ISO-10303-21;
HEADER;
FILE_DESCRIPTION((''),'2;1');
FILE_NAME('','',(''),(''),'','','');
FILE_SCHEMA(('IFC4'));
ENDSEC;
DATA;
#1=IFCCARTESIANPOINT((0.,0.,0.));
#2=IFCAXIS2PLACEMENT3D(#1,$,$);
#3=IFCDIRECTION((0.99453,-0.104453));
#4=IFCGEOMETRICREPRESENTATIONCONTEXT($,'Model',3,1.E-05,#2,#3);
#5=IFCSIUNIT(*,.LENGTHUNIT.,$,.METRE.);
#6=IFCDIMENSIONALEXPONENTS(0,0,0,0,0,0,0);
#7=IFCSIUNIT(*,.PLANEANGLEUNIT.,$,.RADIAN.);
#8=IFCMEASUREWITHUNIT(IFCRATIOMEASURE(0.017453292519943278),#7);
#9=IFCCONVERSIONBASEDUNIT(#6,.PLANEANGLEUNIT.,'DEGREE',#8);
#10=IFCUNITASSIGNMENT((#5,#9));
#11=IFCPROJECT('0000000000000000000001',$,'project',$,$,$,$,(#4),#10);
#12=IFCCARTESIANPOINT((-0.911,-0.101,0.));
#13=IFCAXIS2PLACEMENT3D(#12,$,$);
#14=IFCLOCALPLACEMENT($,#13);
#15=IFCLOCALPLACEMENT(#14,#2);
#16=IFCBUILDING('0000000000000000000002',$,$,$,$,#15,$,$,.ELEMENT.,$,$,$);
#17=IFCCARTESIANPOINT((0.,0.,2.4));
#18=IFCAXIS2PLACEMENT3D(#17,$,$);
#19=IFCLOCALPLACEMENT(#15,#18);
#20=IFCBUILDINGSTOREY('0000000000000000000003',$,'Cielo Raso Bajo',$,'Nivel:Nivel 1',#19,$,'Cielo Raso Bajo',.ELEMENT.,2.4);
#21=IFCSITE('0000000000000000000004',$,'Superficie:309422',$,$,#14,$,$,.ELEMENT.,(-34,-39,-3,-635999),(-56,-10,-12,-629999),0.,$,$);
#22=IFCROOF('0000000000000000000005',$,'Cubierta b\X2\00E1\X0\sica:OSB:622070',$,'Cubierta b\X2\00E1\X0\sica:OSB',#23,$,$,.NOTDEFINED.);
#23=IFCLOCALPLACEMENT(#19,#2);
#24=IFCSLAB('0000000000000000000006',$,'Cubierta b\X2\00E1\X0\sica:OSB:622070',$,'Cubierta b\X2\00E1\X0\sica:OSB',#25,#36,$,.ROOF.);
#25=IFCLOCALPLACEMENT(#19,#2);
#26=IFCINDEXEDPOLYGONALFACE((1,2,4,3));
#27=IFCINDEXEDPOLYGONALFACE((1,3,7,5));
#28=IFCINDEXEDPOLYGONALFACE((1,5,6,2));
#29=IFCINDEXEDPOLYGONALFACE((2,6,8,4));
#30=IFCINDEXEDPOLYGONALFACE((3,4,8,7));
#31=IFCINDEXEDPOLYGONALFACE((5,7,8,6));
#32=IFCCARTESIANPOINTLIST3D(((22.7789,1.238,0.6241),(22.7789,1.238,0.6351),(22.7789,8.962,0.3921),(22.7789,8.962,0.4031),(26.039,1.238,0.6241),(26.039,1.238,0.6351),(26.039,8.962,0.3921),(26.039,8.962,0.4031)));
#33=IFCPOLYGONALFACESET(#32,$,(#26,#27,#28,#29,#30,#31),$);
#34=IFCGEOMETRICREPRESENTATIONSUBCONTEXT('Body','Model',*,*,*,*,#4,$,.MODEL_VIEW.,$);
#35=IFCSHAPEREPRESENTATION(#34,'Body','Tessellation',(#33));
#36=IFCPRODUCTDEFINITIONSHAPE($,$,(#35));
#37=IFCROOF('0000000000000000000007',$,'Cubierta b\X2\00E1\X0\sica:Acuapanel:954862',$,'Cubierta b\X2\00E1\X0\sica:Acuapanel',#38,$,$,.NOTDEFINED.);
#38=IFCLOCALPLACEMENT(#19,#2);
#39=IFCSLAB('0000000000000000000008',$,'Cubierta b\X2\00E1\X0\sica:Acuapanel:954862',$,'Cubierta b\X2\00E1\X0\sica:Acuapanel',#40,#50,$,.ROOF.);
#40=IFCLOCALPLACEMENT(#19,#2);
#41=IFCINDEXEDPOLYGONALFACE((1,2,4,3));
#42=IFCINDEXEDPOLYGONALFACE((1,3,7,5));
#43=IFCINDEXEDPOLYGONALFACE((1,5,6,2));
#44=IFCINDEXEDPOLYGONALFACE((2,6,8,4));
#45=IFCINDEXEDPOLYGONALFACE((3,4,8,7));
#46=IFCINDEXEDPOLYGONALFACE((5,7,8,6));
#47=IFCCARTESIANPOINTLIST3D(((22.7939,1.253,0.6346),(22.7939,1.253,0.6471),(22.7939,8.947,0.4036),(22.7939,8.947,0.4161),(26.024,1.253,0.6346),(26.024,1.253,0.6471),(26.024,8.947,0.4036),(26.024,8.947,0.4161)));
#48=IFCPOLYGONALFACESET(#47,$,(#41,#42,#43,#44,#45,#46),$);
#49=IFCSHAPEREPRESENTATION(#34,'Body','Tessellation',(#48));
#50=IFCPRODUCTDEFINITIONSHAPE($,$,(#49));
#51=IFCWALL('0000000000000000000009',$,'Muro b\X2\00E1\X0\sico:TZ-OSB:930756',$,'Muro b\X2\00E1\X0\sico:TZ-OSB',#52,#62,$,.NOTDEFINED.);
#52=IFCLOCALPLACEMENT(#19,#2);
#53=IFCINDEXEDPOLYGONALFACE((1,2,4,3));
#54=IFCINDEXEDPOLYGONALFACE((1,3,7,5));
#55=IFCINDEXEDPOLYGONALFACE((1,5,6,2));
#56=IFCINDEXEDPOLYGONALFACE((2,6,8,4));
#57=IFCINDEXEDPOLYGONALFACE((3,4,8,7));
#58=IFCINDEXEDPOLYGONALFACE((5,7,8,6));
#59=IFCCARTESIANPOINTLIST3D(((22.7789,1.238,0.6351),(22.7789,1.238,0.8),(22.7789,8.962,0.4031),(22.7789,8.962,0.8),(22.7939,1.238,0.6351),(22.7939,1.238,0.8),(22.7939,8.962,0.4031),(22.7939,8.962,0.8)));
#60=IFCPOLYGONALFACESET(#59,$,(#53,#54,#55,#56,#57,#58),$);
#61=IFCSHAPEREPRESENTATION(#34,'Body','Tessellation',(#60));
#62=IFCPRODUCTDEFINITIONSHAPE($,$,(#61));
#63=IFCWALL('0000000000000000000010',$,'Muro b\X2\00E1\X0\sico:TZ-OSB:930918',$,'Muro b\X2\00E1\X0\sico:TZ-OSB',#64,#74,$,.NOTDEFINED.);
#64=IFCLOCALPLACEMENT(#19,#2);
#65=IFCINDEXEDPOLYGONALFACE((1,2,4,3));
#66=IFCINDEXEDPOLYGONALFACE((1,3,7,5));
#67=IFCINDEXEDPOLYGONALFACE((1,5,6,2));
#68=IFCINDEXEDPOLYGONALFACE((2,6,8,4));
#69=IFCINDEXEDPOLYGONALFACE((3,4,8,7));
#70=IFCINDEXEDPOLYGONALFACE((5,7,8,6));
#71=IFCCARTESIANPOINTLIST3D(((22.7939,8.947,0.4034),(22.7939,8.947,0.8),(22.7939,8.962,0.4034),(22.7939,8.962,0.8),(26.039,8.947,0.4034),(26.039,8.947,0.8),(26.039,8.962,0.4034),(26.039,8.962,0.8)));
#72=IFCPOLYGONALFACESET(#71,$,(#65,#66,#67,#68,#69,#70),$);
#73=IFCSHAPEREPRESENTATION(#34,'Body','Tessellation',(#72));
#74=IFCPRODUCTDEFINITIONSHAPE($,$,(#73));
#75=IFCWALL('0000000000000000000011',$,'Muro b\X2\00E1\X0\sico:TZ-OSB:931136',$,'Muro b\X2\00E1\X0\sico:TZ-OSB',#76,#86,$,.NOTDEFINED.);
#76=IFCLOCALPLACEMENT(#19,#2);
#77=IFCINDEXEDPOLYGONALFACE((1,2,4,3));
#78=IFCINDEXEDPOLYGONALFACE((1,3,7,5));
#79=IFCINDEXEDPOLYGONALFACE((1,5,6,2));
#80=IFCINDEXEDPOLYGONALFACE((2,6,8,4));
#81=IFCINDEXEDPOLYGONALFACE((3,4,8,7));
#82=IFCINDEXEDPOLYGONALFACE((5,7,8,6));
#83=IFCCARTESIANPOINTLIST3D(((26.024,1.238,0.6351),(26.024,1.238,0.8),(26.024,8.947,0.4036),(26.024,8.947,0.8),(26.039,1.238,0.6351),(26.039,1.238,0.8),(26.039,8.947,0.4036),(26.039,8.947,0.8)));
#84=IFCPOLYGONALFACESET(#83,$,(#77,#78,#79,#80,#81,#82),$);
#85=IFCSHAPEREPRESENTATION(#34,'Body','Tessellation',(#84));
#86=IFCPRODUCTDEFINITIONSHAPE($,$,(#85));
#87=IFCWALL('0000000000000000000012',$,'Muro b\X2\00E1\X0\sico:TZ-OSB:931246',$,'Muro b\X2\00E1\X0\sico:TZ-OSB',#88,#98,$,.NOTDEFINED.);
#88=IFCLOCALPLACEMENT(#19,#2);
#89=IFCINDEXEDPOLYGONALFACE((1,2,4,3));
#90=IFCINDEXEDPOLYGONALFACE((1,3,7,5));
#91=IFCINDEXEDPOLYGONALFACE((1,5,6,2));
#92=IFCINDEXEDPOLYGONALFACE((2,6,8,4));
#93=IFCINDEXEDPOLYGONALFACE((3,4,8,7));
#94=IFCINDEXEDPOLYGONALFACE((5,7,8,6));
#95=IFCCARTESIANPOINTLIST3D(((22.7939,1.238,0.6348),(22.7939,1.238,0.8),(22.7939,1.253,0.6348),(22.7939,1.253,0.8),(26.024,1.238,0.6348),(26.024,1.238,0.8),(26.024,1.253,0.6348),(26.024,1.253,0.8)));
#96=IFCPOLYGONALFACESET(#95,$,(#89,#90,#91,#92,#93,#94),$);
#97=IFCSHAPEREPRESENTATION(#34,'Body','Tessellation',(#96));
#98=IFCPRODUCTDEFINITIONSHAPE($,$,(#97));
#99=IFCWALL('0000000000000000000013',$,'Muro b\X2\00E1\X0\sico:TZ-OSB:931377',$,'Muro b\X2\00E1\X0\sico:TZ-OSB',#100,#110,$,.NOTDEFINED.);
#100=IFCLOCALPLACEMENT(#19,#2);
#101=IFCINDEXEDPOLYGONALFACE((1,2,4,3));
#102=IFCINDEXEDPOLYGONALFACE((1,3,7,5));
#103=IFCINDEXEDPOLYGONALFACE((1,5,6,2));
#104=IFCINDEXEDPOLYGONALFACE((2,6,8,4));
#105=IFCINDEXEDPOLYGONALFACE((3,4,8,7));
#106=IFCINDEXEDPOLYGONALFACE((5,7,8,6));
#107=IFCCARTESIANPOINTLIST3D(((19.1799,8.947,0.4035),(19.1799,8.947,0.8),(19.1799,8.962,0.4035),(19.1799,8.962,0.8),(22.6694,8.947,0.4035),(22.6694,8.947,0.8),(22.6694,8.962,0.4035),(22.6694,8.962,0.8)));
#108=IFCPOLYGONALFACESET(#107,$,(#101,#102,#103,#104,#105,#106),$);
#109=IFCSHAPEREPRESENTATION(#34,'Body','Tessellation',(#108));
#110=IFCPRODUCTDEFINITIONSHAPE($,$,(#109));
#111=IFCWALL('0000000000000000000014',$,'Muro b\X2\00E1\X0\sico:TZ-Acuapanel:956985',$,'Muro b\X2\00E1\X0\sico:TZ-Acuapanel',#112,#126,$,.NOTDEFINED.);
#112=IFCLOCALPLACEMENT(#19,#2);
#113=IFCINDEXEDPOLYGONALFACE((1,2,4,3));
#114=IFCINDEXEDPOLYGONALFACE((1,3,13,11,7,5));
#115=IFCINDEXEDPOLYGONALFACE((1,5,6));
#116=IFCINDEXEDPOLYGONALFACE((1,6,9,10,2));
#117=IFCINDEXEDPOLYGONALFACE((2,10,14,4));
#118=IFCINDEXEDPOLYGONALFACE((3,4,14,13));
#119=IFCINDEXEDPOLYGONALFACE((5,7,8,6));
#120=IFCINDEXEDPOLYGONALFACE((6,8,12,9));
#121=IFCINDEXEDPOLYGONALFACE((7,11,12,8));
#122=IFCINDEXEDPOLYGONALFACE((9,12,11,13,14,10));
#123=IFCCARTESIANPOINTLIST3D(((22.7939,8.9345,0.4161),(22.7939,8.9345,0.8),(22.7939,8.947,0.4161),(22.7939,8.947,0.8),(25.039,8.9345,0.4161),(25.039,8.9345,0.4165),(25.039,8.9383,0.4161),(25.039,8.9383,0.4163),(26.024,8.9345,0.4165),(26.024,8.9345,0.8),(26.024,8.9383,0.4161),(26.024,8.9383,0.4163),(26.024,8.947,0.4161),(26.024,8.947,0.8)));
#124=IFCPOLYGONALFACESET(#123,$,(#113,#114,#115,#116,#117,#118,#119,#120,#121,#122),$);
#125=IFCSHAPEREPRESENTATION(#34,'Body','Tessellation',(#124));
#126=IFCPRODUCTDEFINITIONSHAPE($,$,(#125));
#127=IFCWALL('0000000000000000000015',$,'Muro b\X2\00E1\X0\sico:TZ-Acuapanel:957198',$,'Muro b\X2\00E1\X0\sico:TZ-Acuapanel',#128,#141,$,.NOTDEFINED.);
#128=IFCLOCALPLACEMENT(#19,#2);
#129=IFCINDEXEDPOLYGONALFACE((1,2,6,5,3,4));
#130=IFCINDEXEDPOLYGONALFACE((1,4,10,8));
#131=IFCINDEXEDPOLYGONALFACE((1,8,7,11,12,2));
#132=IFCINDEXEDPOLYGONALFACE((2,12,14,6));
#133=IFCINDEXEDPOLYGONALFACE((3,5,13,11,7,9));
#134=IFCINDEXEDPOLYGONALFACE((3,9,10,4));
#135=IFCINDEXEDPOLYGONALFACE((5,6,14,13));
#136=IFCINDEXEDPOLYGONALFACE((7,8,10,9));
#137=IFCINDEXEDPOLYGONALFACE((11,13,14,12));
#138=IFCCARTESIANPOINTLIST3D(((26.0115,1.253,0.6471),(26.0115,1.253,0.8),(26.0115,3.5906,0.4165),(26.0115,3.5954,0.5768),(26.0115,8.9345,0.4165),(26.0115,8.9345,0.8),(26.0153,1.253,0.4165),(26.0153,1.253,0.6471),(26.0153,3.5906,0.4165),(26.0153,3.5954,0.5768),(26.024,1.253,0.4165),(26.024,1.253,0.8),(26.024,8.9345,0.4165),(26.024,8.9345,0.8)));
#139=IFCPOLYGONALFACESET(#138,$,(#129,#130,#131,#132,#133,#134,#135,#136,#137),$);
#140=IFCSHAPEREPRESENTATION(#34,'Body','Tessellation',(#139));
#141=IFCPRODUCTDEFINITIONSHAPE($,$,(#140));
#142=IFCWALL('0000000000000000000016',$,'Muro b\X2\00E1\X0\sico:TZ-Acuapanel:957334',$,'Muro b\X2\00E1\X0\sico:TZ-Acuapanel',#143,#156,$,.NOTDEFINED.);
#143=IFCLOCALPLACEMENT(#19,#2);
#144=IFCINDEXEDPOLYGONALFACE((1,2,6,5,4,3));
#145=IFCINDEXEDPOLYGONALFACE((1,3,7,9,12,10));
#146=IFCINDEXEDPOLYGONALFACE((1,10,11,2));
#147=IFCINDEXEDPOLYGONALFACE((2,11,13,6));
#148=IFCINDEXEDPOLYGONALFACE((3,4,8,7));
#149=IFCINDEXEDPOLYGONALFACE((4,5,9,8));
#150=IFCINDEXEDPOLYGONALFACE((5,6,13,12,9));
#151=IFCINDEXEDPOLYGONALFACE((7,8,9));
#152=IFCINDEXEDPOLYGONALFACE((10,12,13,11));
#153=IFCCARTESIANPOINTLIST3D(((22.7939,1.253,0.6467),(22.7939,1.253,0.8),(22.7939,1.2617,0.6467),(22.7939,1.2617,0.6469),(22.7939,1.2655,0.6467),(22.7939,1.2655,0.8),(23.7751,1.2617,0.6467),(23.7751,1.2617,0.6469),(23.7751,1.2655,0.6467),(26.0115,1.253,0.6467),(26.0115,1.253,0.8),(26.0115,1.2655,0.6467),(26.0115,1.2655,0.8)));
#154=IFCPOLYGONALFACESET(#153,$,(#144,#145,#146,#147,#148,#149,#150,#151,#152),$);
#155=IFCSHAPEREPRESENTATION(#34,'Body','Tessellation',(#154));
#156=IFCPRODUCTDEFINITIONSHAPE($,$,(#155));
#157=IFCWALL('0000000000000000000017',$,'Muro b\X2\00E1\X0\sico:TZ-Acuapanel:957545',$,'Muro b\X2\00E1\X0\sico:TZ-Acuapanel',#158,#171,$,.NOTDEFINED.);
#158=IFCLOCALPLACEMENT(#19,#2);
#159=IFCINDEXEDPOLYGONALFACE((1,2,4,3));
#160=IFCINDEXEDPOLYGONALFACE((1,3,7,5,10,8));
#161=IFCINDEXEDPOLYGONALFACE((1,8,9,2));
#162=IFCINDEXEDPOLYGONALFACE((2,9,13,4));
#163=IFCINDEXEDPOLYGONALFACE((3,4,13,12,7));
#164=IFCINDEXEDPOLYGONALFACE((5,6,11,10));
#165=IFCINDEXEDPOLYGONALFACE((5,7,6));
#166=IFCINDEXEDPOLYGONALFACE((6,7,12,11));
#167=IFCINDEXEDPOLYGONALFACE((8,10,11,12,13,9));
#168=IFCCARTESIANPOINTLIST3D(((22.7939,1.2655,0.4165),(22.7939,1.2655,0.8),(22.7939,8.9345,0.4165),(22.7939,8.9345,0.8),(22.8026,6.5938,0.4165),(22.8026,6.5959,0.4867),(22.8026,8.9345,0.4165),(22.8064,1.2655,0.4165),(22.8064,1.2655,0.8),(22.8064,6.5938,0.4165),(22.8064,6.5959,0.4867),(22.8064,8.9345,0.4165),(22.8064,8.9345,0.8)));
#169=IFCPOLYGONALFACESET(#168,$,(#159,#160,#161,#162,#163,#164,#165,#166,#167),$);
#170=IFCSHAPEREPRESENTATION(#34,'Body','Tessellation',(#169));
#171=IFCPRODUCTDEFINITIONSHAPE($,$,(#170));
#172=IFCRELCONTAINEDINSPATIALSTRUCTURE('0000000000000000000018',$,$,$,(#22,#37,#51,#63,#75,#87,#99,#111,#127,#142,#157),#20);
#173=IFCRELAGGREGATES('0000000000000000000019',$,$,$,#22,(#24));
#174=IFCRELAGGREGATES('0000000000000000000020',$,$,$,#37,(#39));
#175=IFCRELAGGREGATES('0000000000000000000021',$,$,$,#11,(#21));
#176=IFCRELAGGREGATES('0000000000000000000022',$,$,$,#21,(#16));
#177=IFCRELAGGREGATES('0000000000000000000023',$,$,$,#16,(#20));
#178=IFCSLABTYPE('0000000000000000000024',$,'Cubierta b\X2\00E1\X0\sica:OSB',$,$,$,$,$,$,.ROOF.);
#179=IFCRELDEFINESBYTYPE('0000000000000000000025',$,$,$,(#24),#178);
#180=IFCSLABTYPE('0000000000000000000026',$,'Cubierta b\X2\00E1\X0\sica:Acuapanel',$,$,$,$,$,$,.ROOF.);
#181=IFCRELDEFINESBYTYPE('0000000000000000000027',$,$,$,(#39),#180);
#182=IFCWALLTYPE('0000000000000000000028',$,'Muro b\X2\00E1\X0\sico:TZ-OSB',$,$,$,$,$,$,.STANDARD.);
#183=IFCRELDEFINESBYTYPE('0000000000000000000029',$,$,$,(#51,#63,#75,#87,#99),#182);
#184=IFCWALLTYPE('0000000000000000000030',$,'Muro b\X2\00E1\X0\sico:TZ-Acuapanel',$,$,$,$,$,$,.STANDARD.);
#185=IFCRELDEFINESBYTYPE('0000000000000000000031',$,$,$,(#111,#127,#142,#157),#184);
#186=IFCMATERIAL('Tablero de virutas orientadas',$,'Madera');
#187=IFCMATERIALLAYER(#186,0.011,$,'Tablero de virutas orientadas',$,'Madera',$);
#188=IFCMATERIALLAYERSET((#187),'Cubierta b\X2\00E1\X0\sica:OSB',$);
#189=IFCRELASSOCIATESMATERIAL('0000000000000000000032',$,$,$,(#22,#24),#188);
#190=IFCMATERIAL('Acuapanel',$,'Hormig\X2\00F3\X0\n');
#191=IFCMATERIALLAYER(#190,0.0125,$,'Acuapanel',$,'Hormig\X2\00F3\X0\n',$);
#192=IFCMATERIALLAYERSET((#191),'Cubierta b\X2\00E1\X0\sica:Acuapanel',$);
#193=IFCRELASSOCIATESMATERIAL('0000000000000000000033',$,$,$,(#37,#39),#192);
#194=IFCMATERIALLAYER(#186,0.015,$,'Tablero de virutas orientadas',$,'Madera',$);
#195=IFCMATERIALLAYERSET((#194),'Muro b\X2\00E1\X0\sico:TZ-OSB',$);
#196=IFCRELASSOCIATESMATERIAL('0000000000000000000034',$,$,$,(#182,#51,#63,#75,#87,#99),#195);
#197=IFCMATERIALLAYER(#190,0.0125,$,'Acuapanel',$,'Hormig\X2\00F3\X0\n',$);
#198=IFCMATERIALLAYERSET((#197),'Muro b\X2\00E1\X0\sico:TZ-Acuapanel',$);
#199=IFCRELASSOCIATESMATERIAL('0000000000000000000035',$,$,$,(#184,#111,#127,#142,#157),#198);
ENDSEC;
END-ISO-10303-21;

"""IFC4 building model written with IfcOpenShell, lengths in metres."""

from ifc_helpers import new_model, entity, si_unit, converted_unit, direction, frame, frame_2d, origin, place, context, subcontext, project, spatial, polyline, rectangle, extrude, clip, halfspace, bounded_halfspace, material, layer, layer_set, layer_usage, type_object, element, aggregate, save


model = new_model("IFC4")

# Units and contexts
model_context = context("Model", 3, precision=1e-05, world=origin(), true_north=direction((0.99453, -0.104453)))
body_context = subcontext(model_context, "Body", "Model", "MODEL_VIEW")
ifc_project = project(units=[si_unit("LENGTHUNIT", "METRE"), converted_unit("PLANEANGLEUNIT", "DEGREE", entity("IfcRatioMeasure", 0.017453292519943278), si_unit("PLANEANGLEUNIT", "RADIAN"), dimensions=[0, 0, 0, 0, 0, 0, 0])], contexts=[model_context])

# Site, building, storey
site_placement = place(None, frame((-0.911, -0.101, 0.0)))
site = spatial("IfcSite", under=ifc_project, at=site_placement, Name="Superficie:309422", CompositionType="ELEMENT", RefLatitude=(-34, -39, -3, -635999), RefLongitude=(-56, -10, -12, -629999), RefElevation=0.0)
building_placement = place(site_placement, origin())
building = spatial("IfcBuilding", under=site, at=building_placement, CompositionType="ELEMENT")
storey_placement = place(building_placement, frame((0.0, 0.0, 2.4)))
storey = spatial("IfcBuildingStorey", under=building, at=storey_placement, Name="Cielo Raso Bajo", ObjectType="Nivel:Nivel 1", LongName="Cielo Raso Bajo", CompositionType="ELEMENT", Elevation=2.4)

# Roofs, slabs
ifc_material_1 = material(Name="Tablero de virutas orientadas", Category="Madera")
ifc_layer_1 = layer(ifc_material_1, 0.011, Name="Tablero de virutas orientadas", Category="Madera")
ifc_layer_set_1 = layer_set([ifc_layer_1], Name="Cubierta básica:OSB")
roof_1_placement = place(storey_placement, frame((22.7789, 1.238, 0.3921)))
roof_1 = element("IfcRoof", 1, at=roof_1_placement, inside=storey, material=ifc_layer_set_1, Name="Cubierta básica:OSB:622070", ObjectType="Cubierta básica:OSB", PredefinedType="NOTDEFINED")
slab_type_1 = type_object("IfcSlabType", Name="Cubierta básica:OSB", PredefinedType="ROOF")
slab_1_placement = place(roof_1_placement, origin())
slab_1 = element("IfcSlab", 2, at=slab_1_placement, type_object=slab_type_1, material=ifc_layer_set_1, Name="Cubierta básica:OSB:622070", ObjectType="Cubierta básica:OSB", PredefinedType="ROOF", context=body_context, shape_type="SweptSolid", body=[
    extrude(rectangle(XDim=3.26, YDim=7.7275, at=frame_2d((0.0, 0.0), x_axis=(1.0, 0.0))), frame((1.63, 3.862, 0.116), z_axis=(0.0, 0.030015, 0.999549), x_axis=(1.0, 0.0, 0.0)), (0.0, -0.030015, 0.999549), 0.011),
])
aggregate(roof_1, [slab_1])
ifc_material_2 = material(Name="Acuapanel", Category="Hormigón")
ifc_layer_2 = layer(ifc_material_2, 0.0125, Name="Acuapanel", Category="Hormigón")
ifc_layer_set_2 = layer_set([ifc_layer_2], Name="Cubierta básica:Acuapanel")
roof_2_placement = place(storey_placement, frame((22.7939, 1.253, 0.4036)))
roof_2 = element("IfcRoof", 3, at=roof_2_placement, inside=storey, material=ifc_layer_set_2, Name="Cubierta básica:Acuapanel:954862", ObjectType="Cubierta básica:Acuapanel", PredefinedType="NOTDEFINED")
slab_type_2 = type_object("IfcSlabType", Name="Cubierta básica:Acuapanel", PredefinedType="ROOF")
slab_2_placement = place(roof_2_placement, origin())
slab_2 = element("IfcSlab", 4, at=slab_2_placement, type_object=slab_type_2, material=ifc_layer_set_2, Name="Cubierta básica:Acuapanel:954862", ObjectType="Cubierta básica:Acuapanel", PredefinedType="ROOF", context=body_context, shape_type="SweptSolid", body=[
    extrude(rectangle(XDim=3.23, YDim=7.6975, at=frame_2d((0.0, 0.0), x_axis=(1.0, 0.0))), frame((1.615, 3.847, 0.1155), z_axis=(0.0, 0.030015, 0.999549), x_axis=(1.0, 0.0, 0.0)), (0.0, -0.030015, 0.999549), 0.0125),
])
aggregate(roof_2, [slab_2])

# Walls
ifc_layer_3 = layer(ifc_material_1, 0.015, Name="Tablero de virutas orientadas", Category="Madera")
ifc_layer_set_3 = layer_set([ifc_layer_3], Name="Muro básico:TZ-OSB")
ifc_layer_usage_1 = layer_usage(ifc_layer_set_3, "AXIS2", "POSITIVE", -0.0075)
wall_type_1 = type_object("IfcWallType", Name="Muro básico:TZ-OSB", PredefinedType="STANDARD", material=ifc_layer_set_3)
wall_1_placement = place(storey_placement, frame((22.7864, 1.238, 0.4031), z_axis=(0.0, 0.0, 1.0), x_axis=(0.0, 1.0, 0.0)))
element("IfcWall", 5, at=wall_1_placement, inside=storey, type_object=wall_type_1, material=ifc_layer_usage_1, Name="Muro básico:TZ-OSB:930756", ObjectType="Muro básico:TZ-OSB", PredefinedType="NOTDEFINED", context=body_context, shape_type="Clipping", body=[
    clip(extrude(rectangle(XDim=7.724, YDim=0.015, at=frame_2d((3.862, 0.0), x_axis=(-1.0, 0.0))), origin(), (0.0, 0.0, 1.0), 0.3969), halfspace(frame((7.724, -0.0075, 0.0), z_axis=(-0.030015, 0.0, -0.999549), x_axis=(0.0, 1.0, 0.0)), False)),
])
ifc_layer_usage_2 = layer_usage(ifc_layer_set_3, "AXIS2", "POSITIVE", -0.0075)
wall_2_placement = place(storey_placement, frame((22.7939, 8.9545, 0.4034)))
element("IfcWall", 6, at=wall_2_placement, inside=storey, type_object=wall_type_1, material=ifc_layer_usage_2, Name="Muro básico:TZ-OSB:930918", ObjectType="Muro básico:TZ-OSB", PredefinedType="NOTDEFINED", context=body_context, shape_type="SweptSolid", body=[
    extrude(rectangle(XDim=3.245, YDim=0.015, at=frame_2d((1.6225, 0.0), x_axis=(-1.0, 0.0))), origin(), (0.0, 0.0, 1.0), 0.3966),
])
ifc_layer_usage_3 = layer_usage(ifc_layer_set_3, "AXIS2", "POSITIVE", -0.0075)
wall_3_placement = place(storey_placement, frame((26.0315, 8.947, 0.4036), z_axis=(0.0, 0.0, 1.0), x_axis=(0.0, -1.0, 0.0)))
element("IfcWall", 7, at=wall_3_placement, inside=storey, type_object=wall_type_1, material=ifc_layer_usage_3, Name="Muro básico:TZ-OSB:931136", ObjectType="Muro básico:TZ-OSB", PredefinedType="NOTDEFINED", context=body_context, shape_type="Clipping", body=[
    clip(extrude(rectangle(XDim=7.709, YDim=0.015, at=frame_2d((3.8545, 0.0), x_axis=(-1.0, 0.0))), origin(), (0.0, 0.0, 1.0), 0.3964), halfspace(frame((7.709, -0.0075, 0.2315), z_axis=(0.030015, 0.0, -0.999549), x_axis=(0.0, 1.0, 0.0)), False)),
])
ifc_layer_usage_4 = layer_usage(ifc_layer_set_3, "AXIS2", "NEGATIVE", 0.0075)
wall_4_placement = place(storey_placement, frame((22.7939, 1.2455, 0.6348)))
element("IfcWall", 8, at=wall_4_placement, inside=storey, type_object=wall_type_1, material=ifc_layer_usage_4, Name="Muro básico:TZ-OSB:931246", ObjectType="Muro básico:TZ-OSB", PredefinedType="NOTDEFINED", context=body_context, shape_type="SweptSolid", body=[
    extrude(rectangle(XDim=3.23, YDim=0.015, at=frame_2d((1.615, 0.0), x_axis=(-1.0, 0.0))), origin(), (0.0, 0.0, 1.0), 0.1652),
])
ifc_layer_usage_5 = layer_usage(ifc_layer_set_3, "AXIS2", "NEGATIVE", 0.0075)
wall_5_placement = place(storey_placement, frame((22.6694, 8.9545, 0.4035), z_axis=(0.0, 0.0, 1.0), x_axis=(-1.0, 0.0, 0.0)))
element("IfcWall", 9, at=wall_5_placement, inside=storey, type_object=wall_type_1, material=ifc_layer_usage_5, Name="Muro básico:TZ-OSB:931377", ObjectType="Muro básico:TZ-OSB", PredefinedType="NOTDEFINED", context=body_context, shape_type="SweptSolid", body=[
    extrude(rectangle(XDim=3.4895, YDim=0.015, at=frame_2d((1.7448, 0.0), x_axis=(-1.0, 0.0))), origin(), (0.0, 0.0, 1.0), 0.3965),
])
ifc_layer_4 = layer(ifc_material_2, 0.0125, Name="Acuapanel", Category="Hormigón")
ifc_layer_set_4 = layer_set([ifc_layer_4], Name="Muro básico:TZ-Acuapanel")
ifc_layer_usage_6 = layer_usage(ifc_layer_set_4, "AXIS2", "POSITIVE", -0.0063)
wall_type_2 = type_object("IfcWallType", Name="Muro básico:TZ-Acuapanel", PredefinedType="STANDARD", material=ifc_layer_set_4)
wall_6_placement = place(storey_placement, frame((22.7939, 8.9408, 0.4161)))
element("IfcWall", 10, at=wall_6_placement, inside=storey, type_object=wall_type_2, material=ifc_layer_usage_6, Name="Muro básico:TZ-Acuapanel:956985", ObjectType="Muro básico:TZ-Acuapanel", PredefinedType="NOTDEFINED", context=body_context, shape_type="Clipping", body=[
    clip(extrude(rectangle(XDim=3.23, YDim=0.0125, at=frame_2d((1.615, 0.0), x_axis=(-1.0, 0.0))), origin(), (0.0, 0.0, 1.0), 0.3839), bounded_halfspace(frame((3.23, -0.0063, 0.0004), z_axis=(0.0, 0.030015, 0.999549), x_axis=(-1.0, 0.0, 0.0)), True, frame((3.23, -0.0063, 0.0004), z_axis=(0.0, 0.030015, 0.999549), x_axis=(-1.0, 0.0, 0.0)), polyline([(0.0, 0.0), (0.0, -0.0038), (0.985, -0.0038), (0.985, 0.0), (0.9811, 0.0), (0.0038, 0.0), (0.0, 0.0)]))),
])
ifc_layer_usage_7 = layer_usage(ifc_layer_set_4, "AXIS2", "POSITIVE", -0.0063)
wall_7_placement = place(storey_placement, frame((26.0177, 8.9345, 0.4165), z_axis=(0.0, 0.0, 1.0), x_axis=(0.0, -1.0, 0.0)))
element("IfcWall", 11, at=wall_7_placement, inside=storey, type_object=wall_type_2, material=ifc_layer_usage_7, Name="Muro básico:TZ-Acuapanel:957198", ObjectType="Muro básico:TZ-Acuapanel", PredefinedType="NOTDEFINED", context=body_context, shape_type="Clipping", body=[
    clip(extrude(rectangle(XDim=7.6815, YDim=0.0125, at=frame_2d((3.8408, 0.0), x_axis=(-1.0, 0.0))), origin(), (0.0, 0.0, 1.0), 0.3835), bounded_halfspace(frame((7.6815, -0.0063, 0.2307), z_axis=(-0.030015, 0.0, 0.999549), x_axis=(0.0, -1.0, 0.0)), True, frame((7.6815, -0.0063, 0.2307), z_axis=(-0.030015, 0.0, 0.999549), x_axis=(0.0, -1.0, 0.0)), polyline([(0.0, 0.0), (-0.0038, 0.0), (-0.0038, -2.3434), (0.0, -2.3434), (0.0, -0.0038), (0.0, 0.0)]))),
])
ifc_layer_usage_8 = layer_usage(ifc_layer_set_4, "AXIS2", "POSITIVE", -0.0063)
wall_8_placement = place(storey_placement, frame((26.0115, 1.2593, 0.6467), z_axis=(0.0, 0.0, 1.0), x_axis=(-1.0, 0.0, 0.0)))
element("IfcWall", 12, at=wall_8_placement, inside=storey, type_object=wall_type_2, material=ifc_layer_usage_8, Name="Muro básico:TZ-Acuapanel:957334", ObjectType="Muro básico:TZ-Acuapanel", PredefinedType="NOTDEFINED", context=body_context, shape_type="Clipping", body=[
    clip(extrude(rectangle(XDim=3.2175, YDim=0.0125, at=frame_2d((1.6088, 0.0), x_axis=(-1.0, 0.0))), origin(), (0.0, 0.0, 1.0), 0.1533), bounded_halfspace(frame((3.2175, -0.0062, 0.0), z_axis=(0.0, -0.030015, 0.999549), x_axis=(1.0, 0.0, 0.0)), True, frame((3.2175, -0.0062, 0.0), z_axis=(0.0, -0.030015, 0.999549), x_axis=(1.0, 0.0, 0.0)), polyline([(0.0, 0.0), (0.0, 0.0038), (-0.9811, 0.0038), (-0.9811, 0.0), (-0.0038, 0.0), (0.0, 0.0)]))),
])
ifc_layer_usage_9 = layer_usage(ifc_layer_set_4, "AXIS2", "POSITIVE", -0.0063)
wall_9_placement = place(storey_placement, frame((22.8002, 1.2655, 0.4165), z_axis=(0.0, 0.0, 1.0), x_axis=(0.0, 1.0, 0.0)))
element("IfcWall", 13, at=wall_9_placement, inside=storey, type_object=wall_type_2, material=ifc_layer_usage_9, Name="Muro básico:TZ-Acuapanel:957545", ObjectType="Muro básico:TZ-Acuapanel", PredefinedType="NOTDEFINED", context=body_context, shape_type="Clipping", body=[
    clip(extrude(rectangle(XDim=7.669, YDim=0.0125, at=frame_2d((3.8345, 0.0), x_axis=(-1.0, 0.0))), origin(), (0.0, 0.0, 1.0), 0.3835), bounded_halfspace(frame((7.669, -0.0063, 0.0), z_axis=(0.030015, 0.0, 0.999549), x_axis=(0.0, 1.0, 0.0)), True, frame((7.669, -0.0063, 0.0), z_axis=(0.030015, 0.0, 0.999549), x_axis=(0.0, 1.0, 0.0)), polyline([(0.0, 0.0), (0.0038, 0.0), (0.0038, 2.3396), (0.0, 2.3396), (0.0, 0.0)]))),
])

save(model, "model.ifc")
